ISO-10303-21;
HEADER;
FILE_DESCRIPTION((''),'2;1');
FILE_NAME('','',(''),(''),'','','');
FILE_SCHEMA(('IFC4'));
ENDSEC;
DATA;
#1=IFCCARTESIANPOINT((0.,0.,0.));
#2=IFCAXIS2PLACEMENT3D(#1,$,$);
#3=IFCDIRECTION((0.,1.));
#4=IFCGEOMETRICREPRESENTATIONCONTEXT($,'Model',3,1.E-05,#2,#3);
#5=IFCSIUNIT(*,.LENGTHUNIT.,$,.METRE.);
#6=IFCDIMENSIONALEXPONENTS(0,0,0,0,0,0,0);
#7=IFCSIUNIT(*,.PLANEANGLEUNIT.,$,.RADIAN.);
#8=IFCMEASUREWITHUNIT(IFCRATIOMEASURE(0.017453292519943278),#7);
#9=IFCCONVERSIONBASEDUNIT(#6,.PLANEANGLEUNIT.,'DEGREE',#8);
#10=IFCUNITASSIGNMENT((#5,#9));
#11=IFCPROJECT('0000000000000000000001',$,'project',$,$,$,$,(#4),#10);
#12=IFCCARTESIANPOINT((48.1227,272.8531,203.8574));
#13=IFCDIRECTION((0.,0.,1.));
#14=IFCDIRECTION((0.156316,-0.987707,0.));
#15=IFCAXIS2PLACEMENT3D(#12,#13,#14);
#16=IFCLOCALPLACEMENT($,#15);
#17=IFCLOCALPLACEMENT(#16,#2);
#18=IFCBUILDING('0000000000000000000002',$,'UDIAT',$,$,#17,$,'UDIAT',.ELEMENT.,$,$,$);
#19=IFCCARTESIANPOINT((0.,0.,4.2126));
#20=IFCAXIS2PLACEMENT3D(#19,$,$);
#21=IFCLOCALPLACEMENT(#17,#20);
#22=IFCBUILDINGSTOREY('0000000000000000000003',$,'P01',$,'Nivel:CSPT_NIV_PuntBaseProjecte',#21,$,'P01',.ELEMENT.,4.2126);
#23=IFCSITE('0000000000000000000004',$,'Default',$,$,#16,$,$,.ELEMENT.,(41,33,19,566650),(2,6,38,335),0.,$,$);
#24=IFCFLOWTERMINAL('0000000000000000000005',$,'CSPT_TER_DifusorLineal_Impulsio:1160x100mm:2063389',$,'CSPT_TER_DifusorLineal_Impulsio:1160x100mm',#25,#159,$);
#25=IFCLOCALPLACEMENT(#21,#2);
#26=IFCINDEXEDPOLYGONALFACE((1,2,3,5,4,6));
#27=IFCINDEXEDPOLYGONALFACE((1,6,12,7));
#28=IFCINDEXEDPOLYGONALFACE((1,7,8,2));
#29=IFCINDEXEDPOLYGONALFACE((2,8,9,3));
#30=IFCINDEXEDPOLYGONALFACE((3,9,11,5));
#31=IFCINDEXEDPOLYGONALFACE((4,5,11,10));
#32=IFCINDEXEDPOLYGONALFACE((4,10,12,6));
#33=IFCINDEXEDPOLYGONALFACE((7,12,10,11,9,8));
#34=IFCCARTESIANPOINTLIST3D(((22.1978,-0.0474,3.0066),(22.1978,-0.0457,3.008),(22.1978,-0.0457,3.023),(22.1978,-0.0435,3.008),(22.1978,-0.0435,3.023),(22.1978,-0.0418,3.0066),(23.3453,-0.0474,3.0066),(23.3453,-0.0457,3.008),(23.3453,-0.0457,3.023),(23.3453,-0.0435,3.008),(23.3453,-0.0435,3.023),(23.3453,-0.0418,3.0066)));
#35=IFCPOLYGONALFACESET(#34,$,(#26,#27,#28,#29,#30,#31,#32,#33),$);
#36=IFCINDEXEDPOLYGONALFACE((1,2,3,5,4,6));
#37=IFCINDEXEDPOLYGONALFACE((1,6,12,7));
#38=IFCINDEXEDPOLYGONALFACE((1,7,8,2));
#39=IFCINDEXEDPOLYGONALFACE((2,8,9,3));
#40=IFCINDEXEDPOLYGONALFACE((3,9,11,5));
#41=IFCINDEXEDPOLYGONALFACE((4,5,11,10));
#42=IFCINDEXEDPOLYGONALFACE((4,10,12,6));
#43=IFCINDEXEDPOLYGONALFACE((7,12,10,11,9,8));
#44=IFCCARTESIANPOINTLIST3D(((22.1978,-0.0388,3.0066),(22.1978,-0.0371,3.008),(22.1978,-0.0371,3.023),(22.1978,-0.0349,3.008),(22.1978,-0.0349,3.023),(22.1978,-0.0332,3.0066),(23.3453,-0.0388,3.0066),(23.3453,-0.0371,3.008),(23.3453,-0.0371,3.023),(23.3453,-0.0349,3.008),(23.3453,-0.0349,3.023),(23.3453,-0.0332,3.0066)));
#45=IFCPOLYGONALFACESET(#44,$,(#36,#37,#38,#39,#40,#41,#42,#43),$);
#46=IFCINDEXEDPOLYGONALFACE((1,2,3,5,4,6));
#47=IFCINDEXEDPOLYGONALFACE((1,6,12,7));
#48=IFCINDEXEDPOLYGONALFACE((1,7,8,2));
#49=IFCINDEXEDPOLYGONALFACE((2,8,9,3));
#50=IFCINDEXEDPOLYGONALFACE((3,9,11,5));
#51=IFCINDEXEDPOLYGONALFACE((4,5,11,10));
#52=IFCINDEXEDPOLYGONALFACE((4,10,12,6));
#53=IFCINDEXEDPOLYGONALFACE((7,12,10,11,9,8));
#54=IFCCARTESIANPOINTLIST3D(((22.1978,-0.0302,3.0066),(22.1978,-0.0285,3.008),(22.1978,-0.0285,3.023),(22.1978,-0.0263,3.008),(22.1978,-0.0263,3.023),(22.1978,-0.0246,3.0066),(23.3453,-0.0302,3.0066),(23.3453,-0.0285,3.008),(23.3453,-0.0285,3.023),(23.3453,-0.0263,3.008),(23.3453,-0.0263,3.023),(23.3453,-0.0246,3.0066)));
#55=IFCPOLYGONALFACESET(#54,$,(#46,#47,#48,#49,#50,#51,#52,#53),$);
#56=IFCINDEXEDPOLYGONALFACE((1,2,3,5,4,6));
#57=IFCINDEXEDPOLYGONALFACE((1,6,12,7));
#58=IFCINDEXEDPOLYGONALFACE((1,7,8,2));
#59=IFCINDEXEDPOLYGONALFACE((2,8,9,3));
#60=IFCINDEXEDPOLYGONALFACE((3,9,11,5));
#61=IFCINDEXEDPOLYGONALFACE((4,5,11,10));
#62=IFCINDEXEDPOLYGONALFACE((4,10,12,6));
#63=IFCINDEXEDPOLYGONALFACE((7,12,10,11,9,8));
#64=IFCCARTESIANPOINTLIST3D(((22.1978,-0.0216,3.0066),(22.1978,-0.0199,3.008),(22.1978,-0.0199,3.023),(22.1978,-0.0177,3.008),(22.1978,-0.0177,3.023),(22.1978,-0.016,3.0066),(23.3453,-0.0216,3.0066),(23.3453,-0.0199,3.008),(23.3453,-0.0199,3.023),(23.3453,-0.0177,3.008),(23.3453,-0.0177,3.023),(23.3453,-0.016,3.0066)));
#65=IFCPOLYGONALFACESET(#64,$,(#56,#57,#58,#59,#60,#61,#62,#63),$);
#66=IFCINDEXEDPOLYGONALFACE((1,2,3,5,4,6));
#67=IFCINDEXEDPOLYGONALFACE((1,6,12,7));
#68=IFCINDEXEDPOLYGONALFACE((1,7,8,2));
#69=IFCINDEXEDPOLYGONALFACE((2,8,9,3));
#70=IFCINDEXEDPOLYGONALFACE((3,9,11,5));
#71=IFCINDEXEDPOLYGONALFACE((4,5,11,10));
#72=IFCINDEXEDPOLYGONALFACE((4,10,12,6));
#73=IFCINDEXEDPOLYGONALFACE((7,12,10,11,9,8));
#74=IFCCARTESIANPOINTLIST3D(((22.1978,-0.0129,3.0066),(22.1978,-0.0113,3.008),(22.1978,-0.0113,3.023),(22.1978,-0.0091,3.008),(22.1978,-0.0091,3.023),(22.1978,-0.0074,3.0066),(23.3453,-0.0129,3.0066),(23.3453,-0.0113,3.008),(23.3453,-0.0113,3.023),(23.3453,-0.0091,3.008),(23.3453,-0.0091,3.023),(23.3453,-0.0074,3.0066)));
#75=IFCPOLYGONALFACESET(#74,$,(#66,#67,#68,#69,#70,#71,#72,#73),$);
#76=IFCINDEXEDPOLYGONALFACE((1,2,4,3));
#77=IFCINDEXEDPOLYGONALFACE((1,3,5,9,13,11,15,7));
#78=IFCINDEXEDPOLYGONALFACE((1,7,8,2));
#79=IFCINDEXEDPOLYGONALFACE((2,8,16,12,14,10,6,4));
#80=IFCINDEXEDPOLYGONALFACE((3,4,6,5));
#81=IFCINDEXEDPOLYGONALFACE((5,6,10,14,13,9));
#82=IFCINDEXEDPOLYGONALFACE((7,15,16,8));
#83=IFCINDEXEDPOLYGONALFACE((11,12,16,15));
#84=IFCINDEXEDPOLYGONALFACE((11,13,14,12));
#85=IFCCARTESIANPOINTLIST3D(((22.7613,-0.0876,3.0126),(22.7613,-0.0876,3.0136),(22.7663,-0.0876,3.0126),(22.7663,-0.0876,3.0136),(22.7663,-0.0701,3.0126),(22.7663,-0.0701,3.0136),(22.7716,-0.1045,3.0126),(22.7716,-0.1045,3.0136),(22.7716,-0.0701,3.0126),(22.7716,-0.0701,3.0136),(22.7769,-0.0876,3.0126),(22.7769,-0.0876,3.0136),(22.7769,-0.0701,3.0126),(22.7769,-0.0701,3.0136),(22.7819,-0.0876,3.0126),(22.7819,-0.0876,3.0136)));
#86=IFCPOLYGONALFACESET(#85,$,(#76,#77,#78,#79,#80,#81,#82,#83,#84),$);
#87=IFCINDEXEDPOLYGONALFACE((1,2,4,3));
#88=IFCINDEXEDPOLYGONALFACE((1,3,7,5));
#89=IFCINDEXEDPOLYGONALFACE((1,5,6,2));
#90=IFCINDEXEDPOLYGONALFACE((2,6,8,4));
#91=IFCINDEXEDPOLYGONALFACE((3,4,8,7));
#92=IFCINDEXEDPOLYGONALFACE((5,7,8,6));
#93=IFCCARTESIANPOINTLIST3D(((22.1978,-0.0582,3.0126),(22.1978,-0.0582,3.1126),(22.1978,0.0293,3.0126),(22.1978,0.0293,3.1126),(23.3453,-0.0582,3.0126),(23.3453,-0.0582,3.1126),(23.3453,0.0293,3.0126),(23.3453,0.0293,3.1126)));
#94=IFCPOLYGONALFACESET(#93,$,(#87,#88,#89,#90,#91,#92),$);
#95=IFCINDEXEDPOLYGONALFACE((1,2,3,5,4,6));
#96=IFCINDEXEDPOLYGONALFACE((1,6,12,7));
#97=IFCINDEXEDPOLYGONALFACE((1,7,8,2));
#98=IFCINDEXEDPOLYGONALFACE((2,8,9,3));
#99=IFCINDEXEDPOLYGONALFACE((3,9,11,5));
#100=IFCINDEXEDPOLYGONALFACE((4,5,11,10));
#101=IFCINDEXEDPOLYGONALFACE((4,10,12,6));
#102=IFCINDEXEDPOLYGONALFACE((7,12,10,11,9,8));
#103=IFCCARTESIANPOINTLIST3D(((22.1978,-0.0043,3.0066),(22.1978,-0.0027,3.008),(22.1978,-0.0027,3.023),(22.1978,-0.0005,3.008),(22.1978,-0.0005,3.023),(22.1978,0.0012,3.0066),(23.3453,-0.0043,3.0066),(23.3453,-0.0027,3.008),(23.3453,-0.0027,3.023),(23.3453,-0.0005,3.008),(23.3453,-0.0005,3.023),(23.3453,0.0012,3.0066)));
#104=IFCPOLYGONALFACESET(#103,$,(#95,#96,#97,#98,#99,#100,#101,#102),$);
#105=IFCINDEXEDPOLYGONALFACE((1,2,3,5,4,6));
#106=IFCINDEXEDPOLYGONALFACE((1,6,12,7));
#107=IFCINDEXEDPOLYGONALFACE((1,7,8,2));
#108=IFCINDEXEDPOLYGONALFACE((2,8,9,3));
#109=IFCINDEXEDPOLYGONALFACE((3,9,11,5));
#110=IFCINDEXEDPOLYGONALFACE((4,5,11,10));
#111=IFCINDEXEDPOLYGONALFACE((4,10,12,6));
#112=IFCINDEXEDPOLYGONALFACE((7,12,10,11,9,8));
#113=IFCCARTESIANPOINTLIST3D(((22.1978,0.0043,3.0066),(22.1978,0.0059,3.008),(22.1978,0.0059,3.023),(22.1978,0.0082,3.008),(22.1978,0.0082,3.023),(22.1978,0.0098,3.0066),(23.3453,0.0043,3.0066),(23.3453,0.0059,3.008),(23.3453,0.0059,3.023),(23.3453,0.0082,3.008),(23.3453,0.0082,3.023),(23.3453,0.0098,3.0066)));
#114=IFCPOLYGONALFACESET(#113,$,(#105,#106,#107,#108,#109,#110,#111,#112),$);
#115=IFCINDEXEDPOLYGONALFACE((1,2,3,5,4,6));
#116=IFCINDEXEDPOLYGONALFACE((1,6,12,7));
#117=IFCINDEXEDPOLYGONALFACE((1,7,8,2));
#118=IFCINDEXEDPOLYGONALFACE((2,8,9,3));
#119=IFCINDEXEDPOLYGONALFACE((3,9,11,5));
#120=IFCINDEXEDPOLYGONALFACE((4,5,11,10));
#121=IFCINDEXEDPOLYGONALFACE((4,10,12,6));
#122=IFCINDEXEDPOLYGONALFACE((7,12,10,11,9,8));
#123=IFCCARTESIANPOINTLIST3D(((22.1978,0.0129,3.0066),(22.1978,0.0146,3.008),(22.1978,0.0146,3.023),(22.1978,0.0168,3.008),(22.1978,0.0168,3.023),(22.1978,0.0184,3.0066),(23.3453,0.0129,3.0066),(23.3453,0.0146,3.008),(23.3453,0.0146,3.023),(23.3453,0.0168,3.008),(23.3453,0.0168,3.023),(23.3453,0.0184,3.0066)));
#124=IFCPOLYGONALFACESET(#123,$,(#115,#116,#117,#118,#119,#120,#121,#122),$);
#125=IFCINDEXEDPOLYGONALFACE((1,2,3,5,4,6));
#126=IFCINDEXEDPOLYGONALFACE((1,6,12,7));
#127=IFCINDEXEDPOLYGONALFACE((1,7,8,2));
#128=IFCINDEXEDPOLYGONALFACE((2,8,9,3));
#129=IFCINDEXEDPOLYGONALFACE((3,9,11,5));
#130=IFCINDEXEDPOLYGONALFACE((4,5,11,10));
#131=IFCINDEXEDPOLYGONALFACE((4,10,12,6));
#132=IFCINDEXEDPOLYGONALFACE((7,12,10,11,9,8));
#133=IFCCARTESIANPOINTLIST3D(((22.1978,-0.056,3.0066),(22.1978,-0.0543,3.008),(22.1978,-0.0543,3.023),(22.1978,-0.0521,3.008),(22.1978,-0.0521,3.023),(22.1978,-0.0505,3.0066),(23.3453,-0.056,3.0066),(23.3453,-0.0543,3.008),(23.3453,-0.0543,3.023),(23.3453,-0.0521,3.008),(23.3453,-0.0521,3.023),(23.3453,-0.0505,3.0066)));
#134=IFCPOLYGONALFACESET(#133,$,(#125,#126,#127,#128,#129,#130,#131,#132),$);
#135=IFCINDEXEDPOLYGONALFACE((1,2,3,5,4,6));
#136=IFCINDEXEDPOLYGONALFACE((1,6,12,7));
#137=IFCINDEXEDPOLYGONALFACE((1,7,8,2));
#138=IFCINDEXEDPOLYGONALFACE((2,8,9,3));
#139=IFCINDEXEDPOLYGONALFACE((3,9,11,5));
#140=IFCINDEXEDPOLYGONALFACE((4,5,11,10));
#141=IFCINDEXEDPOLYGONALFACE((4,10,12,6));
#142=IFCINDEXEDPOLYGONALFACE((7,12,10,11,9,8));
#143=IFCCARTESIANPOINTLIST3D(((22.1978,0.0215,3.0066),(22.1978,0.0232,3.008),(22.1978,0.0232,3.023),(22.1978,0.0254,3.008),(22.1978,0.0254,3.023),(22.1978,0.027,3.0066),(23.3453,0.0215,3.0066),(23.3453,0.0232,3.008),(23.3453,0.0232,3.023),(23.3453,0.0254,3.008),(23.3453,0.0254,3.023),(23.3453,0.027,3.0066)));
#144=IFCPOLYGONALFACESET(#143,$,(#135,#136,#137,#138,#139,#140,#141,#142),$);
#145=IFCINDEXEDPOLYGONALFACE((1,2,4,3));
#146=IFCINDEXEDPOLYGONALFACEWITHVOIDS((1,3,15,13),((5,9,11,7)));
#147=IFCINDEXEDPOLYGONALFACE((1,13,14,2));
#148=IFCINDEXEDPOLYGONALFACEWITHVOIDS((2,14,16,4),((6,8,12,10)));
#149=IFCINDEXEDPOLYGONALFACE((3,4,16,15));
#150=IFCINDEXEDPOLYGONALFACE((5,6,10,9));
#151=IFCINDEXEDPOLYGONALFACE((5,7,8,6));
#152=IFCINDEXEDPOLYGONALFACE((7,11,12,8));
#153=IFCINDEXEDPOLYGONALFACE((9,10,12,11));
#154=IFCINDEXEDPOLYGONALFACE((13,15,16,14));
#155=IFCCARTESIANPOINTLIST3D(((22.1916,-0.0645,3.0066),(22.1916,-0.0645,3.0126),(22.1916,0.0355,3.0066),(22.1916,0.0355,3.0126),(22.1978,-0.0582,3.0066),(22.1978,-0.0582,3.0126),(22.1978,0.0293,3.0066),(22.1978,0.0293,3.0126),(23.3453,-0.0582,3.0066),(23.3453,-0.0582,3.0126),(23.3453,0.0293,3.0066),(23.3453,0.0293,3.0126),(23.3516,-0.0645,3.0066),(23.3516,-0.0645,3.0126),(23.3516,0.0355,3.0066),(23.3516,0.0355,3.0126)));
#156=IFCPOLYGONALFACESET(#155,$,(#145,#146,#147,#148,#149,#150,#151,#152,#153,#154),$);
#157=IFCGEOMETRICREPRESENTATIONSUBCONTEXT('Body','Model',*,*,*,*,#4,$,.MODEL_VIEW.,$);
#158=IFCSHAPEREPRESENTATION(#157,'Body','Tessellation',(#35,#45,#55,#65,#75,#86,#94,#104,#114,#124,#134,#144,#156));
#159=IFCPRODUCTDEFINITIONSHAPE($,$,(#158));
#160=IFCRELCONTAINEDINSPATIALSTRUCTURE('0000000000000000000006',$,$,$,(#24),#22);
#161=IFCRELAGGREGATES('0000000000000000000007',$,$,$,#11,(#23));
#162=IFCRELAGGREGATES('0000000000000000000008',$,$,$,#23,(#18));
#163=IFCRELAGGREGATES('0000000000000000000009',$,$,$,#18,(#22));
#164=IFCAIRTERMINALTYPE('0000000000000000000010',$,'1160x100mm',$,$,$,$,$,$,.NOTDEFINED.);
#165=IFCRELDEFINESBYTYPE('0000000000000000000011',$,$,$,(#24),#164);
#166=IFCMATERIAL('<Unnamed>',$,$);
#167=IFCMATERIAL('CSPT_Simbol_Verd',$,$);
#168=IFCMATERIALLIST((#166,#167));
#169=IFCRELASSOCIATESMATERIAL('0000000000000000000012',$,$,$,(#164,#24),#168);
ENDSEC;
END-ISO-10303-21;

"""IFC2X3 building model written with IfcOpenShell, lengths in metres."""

from ifc_helpers import new_model, entity, si_unit, converted_unit, direction, frame, origin, origin_2d_with_axis, place, context, subcontext, project, spatial, polyline, rectangle, outline, extrude, source, transform, mapped, material, material_list, type_object, type_shapes, element, save


model = new_model("IFC2X3")

# Units and contexts
model_context = context("Model", 3, precision=1e-05, world=origin(), true_north=direction((0.0, 1.0)))
body_context = subcontext(model_context, "Body", "Model", "MODEL_VIEW")
ifc_project = project(units=[si_unit("LENGTHUNIT", "METRE"), converted_unit("PLANEANGLEUNIT", "DEGREE", entity("IfcRatioMeasure", 0.017453292519943278), si_unit("PLANEANGLEUNIT", "RADIAN"), dimensions=[0, 0, 0, 0, 0, 0, 0])], contexts=[model_context])

# Site, building, storey
site_placement = place(None, frame((48.1227, 272.8531, 203.8574), z_axis=(0.0, 0.0, 1.0), x_axis=(0.156316, -0.987707, 0.0)))
site = spatial("IfcSite", under=ifc_project, at=site_placement, Name="Default", CompositionType="ELEMENT", RefLatitude=(41, 33, 19, 566650), RefLongitude=(2, 6, 38, 335), RefElevation=0.0)
building_placement = place(site_placement, origin())
building = spatial("IfcBuilding", under=site, at=building_placement, Name="UDIAT", LongName="UDIAT", CompositionType="ELEMENT")
storey_placement = place(building_placement, frame((0.0, 0.0, 4.2126)))
storey = spatial("IfcBuildingStorey", under=building, at=storey_placement, Name="P01", ObjectType="Nivel:CSPT_NIV_PuntBaseProjecte", LongName="P01", CompositionType="ELEMENT", Elevation=4.2126)

# Shared definitions
ifc_material_1 = material(Name="<Unnamed>")

# Flow terminal
ifc_material_2 = material(Name="CSPT_Simbol_Verd")
ifc_material_list = material_list([ifc_material_1, ifc_material_2])
air_terminal_type = type_object("IfcAirTerminalType", Name="1160x100mm", PredefinedType="NOTDEFINED", material=ifc_material_list)
shared_shape_1 = source(origin(), body_context, "Body", "SweptSolid", [
    extrude(outline(polyline([(0.0037, 0.0028), (0.0059, 0.0028), (0.0016, 0.0063), (0.002, 0.0042), (-0.0074, -0.0074), (-0.0057, -0.0088), (0.0037, 0.0028)])), frame((-0.5737, 0.0301, -0.0001), z_axis=(1.0, 0.0, 0.0), x_axis=(0.0, -0.776119, -0.630587)), (0.0, 0.0, 1.0), 1.1475),
    extrude(outline(polyline([(0.0037, 0.0028), (0.0059, 0.0028), (0.0016, 0.0063), (0.002, 0.0042), (-0.0074, -0.0074), (-0.0057, -0.0088), (0.0037, 0.0028)])), frame((-0.5737, 0.0215, -0.0001), z_axis=(1.0, 0.0, 0.0), x_axis=(0.0, -0.776119, -0.630587)), (0.0, 0.0, 1.0), 1.1475),
    extrude(outline(polyline([(0.0037, 0.0028), (0.0059, 0.0028), (0.0016, 0.0063), (0.002, 0.0042), (-0.0074, -0.0074), (-0.0057, -0.0088), (0.0037, 0.0028)])), frame((-0.5737, 0.0129, -0.0001), z_axis=(1.0, 0.0, 0.0), x_axis=(0.0, -0.776119, -0.630587)), (0.0, 0.0, 1.0), 1.1475),
    extrude(outline(polyline([(0.0037, 0.0028), (0.0059, 0.0028), (0.0016, 0.0063), (0.002, 0.0042), (-0.0074, -0.0074), (-0.0057, -0.0088), (0.0037, 0.0028)])), frame((-0.5737, 0.0043, -0.0001), z_axis=(1.0, 0.0, 0.0), x_axis=(0.0, -0.776119, -0.630587)), (0.0, 0.0, 1.0), 1.1475),
    extrude(outline(polyline([(0.0037, 0.0028), (0.0059, 0.0028), (0.0016, 0.0063), (0.002, 0.0042), (-0.0074, -0.0074), (-0.0057, -0.0088), (0.0037, 0.0028)])), frame((-0.5737, -0.0043, -0.0001), z_axis=(1.0, 0.0, 0.0), x_axis=(0.0, -0.776119, -0.630587)), (0.0, 0.0, 1.0), 1.1475),
    extrude(outline(polyline([(0.0, -0.013), (0.0053, -0.013), (0.0053, 0.0045), (0.0103, 0.0045), (0.0, 0.0213), (-0.0103, 0.0045), (-0.0053, 0.0045), (-0.0053, -0.013), (0.0, -0.013)])), frame((0.0, 0.0687, 0.0)), (0.0, 0.0, 1.0), 0.001),
    extrude(rectangle(XDim=1.1475, YDim=0.0875, at=origin_2d_with_axis()), frame((0.0, 0.0, 0.0), z_axis=(0.0, 0.0, 1.0), x_axis=(-1.0, 0.0, 0.0)), (0.0, 0.0, 1.0), 0.1),
    extrude(outline(polyline([(0.0037, 0.0028), (0.0059, 0.0028), (0.0016, 0.0063), (0.002, 0.0042), (-0.0074, -0.0074), (-0.0057, -0.0088), (0.0037, 0.0028)])), frame((-0.5737, -0.0129, -0.0001), z_axis=(1.0, 0.0, 0.0), x_axis=(0.0, -0.776119, -0.630587)), (0.0, 0.0, 1.0), 1.1475),
    extrude(outline(polyline([(0.0037, 0.0028), (0.0059, 0.0028), (0.0016, 0.0063), (0.002, 0.0042), (-0.0074, -0.0074), (-0.0057, -0.0088), (0.0037, 0.0028)])), frame((-0.5737, -0.0215, -0.0001), z_axis=(1.0, 0.0, 0.0), x_axis=(0.0, -0.776119, -0.630587)), (0.0, 0.0, 1.0), 1.1475),
    extrude(outline(polyline([(0.0037, 0.0028), (0.0059, 0.0028), (0.0016, 0.0063), (0.002, 0.0042), (-0.0074, -0.0074), (-0.0057, -0.0088), (0.0037, 0.0028)])), frame((-0.5737, -0.0301, -0.0001), z_axis=(1.0, 0.0, 0.0), x_axis=(0.0, -0.776119, -0.630587)), (0.0, 0.0, 1.0), 1.1475),
    extrude(outline(polyline([(0.0037, 0.0028), (0.0059, 0.0028), (0.0016, 0.0063), (0.002, 0.0042), (-0.0074, -0.0074), (-0.0057, -0.0088), (0.0037, 0.0028)])), frame((-0.5737, 0.0388, -0.0001), z_axis=(1.0, 0.0, 0.0), x_axis=(0.0, -0.776119, -0.630587)), (0.0, 0.0, 1.0), 1.1475),
    extrude(outline(polyline([(0.0037, 0.0028), (0.0059, 0.0028), (0.0016, 0.0063), (0.002, 0.0042), (-0.0074, -0.0074), (-0.0057, -0.0088), (0.0037, 0.0028)])), frame((-0.5737, -0.0387, -0.0001), z_axis=(1.0, 0.0, 0.0), x_axis=(0.0, -0.776119, -0.630587)), (0.0, 0.0, 1.0), 1.1475),
    extrude(outline(polyline([(-0.58, -0.05), (0.58, -0.05), (0.58, 0.05), (-0.58, 0.05), (-0.58, -0.05)]), holes=[polyline([(-0.5738, -0.0438), (-0.5738, 0.0437), (0.5737, 0.0437), (0.5737, -0.0438), (-0.5738, -0.0438)])]), frame((0.0, 0.0, -0.006), z_axis=(0.0, 0.0, 1.0), x_axis=(-1.0, 0.0, 0.0)), (0.0, 0.0, 1.0), 0.006),
])
type_shapes(air_terminal_type, [shared_shape_1])
for number, where, z_axis, x_axis, name in (
    (1, (22.7716, -0.0145, 3.0126), (0.0, 0.0, 1.0), (-1.0, 0.0, 0.0), "CSPT_TER_DifusorLineal_Impulsio:1160x100mm:2063389"),
):
    element("IfcFlowTerminal", number, at=place(storey_placement, frame(where, z_axis=z_axis, x_axis=x_axis)), inside=storey, type_object=air_terminal_type, material=ifc_material_list, Name=name, ObjectType="CSPT_TER_DifusorLineal_Impulsio:1160x100mm", context=body_context, shape_type="MappedRepresentation", body=[
        mapped(shared_shape_1, transform((0.0, 0.0, 0.0), scale=1.0)),
    ])

save(model, "model.ifc")
